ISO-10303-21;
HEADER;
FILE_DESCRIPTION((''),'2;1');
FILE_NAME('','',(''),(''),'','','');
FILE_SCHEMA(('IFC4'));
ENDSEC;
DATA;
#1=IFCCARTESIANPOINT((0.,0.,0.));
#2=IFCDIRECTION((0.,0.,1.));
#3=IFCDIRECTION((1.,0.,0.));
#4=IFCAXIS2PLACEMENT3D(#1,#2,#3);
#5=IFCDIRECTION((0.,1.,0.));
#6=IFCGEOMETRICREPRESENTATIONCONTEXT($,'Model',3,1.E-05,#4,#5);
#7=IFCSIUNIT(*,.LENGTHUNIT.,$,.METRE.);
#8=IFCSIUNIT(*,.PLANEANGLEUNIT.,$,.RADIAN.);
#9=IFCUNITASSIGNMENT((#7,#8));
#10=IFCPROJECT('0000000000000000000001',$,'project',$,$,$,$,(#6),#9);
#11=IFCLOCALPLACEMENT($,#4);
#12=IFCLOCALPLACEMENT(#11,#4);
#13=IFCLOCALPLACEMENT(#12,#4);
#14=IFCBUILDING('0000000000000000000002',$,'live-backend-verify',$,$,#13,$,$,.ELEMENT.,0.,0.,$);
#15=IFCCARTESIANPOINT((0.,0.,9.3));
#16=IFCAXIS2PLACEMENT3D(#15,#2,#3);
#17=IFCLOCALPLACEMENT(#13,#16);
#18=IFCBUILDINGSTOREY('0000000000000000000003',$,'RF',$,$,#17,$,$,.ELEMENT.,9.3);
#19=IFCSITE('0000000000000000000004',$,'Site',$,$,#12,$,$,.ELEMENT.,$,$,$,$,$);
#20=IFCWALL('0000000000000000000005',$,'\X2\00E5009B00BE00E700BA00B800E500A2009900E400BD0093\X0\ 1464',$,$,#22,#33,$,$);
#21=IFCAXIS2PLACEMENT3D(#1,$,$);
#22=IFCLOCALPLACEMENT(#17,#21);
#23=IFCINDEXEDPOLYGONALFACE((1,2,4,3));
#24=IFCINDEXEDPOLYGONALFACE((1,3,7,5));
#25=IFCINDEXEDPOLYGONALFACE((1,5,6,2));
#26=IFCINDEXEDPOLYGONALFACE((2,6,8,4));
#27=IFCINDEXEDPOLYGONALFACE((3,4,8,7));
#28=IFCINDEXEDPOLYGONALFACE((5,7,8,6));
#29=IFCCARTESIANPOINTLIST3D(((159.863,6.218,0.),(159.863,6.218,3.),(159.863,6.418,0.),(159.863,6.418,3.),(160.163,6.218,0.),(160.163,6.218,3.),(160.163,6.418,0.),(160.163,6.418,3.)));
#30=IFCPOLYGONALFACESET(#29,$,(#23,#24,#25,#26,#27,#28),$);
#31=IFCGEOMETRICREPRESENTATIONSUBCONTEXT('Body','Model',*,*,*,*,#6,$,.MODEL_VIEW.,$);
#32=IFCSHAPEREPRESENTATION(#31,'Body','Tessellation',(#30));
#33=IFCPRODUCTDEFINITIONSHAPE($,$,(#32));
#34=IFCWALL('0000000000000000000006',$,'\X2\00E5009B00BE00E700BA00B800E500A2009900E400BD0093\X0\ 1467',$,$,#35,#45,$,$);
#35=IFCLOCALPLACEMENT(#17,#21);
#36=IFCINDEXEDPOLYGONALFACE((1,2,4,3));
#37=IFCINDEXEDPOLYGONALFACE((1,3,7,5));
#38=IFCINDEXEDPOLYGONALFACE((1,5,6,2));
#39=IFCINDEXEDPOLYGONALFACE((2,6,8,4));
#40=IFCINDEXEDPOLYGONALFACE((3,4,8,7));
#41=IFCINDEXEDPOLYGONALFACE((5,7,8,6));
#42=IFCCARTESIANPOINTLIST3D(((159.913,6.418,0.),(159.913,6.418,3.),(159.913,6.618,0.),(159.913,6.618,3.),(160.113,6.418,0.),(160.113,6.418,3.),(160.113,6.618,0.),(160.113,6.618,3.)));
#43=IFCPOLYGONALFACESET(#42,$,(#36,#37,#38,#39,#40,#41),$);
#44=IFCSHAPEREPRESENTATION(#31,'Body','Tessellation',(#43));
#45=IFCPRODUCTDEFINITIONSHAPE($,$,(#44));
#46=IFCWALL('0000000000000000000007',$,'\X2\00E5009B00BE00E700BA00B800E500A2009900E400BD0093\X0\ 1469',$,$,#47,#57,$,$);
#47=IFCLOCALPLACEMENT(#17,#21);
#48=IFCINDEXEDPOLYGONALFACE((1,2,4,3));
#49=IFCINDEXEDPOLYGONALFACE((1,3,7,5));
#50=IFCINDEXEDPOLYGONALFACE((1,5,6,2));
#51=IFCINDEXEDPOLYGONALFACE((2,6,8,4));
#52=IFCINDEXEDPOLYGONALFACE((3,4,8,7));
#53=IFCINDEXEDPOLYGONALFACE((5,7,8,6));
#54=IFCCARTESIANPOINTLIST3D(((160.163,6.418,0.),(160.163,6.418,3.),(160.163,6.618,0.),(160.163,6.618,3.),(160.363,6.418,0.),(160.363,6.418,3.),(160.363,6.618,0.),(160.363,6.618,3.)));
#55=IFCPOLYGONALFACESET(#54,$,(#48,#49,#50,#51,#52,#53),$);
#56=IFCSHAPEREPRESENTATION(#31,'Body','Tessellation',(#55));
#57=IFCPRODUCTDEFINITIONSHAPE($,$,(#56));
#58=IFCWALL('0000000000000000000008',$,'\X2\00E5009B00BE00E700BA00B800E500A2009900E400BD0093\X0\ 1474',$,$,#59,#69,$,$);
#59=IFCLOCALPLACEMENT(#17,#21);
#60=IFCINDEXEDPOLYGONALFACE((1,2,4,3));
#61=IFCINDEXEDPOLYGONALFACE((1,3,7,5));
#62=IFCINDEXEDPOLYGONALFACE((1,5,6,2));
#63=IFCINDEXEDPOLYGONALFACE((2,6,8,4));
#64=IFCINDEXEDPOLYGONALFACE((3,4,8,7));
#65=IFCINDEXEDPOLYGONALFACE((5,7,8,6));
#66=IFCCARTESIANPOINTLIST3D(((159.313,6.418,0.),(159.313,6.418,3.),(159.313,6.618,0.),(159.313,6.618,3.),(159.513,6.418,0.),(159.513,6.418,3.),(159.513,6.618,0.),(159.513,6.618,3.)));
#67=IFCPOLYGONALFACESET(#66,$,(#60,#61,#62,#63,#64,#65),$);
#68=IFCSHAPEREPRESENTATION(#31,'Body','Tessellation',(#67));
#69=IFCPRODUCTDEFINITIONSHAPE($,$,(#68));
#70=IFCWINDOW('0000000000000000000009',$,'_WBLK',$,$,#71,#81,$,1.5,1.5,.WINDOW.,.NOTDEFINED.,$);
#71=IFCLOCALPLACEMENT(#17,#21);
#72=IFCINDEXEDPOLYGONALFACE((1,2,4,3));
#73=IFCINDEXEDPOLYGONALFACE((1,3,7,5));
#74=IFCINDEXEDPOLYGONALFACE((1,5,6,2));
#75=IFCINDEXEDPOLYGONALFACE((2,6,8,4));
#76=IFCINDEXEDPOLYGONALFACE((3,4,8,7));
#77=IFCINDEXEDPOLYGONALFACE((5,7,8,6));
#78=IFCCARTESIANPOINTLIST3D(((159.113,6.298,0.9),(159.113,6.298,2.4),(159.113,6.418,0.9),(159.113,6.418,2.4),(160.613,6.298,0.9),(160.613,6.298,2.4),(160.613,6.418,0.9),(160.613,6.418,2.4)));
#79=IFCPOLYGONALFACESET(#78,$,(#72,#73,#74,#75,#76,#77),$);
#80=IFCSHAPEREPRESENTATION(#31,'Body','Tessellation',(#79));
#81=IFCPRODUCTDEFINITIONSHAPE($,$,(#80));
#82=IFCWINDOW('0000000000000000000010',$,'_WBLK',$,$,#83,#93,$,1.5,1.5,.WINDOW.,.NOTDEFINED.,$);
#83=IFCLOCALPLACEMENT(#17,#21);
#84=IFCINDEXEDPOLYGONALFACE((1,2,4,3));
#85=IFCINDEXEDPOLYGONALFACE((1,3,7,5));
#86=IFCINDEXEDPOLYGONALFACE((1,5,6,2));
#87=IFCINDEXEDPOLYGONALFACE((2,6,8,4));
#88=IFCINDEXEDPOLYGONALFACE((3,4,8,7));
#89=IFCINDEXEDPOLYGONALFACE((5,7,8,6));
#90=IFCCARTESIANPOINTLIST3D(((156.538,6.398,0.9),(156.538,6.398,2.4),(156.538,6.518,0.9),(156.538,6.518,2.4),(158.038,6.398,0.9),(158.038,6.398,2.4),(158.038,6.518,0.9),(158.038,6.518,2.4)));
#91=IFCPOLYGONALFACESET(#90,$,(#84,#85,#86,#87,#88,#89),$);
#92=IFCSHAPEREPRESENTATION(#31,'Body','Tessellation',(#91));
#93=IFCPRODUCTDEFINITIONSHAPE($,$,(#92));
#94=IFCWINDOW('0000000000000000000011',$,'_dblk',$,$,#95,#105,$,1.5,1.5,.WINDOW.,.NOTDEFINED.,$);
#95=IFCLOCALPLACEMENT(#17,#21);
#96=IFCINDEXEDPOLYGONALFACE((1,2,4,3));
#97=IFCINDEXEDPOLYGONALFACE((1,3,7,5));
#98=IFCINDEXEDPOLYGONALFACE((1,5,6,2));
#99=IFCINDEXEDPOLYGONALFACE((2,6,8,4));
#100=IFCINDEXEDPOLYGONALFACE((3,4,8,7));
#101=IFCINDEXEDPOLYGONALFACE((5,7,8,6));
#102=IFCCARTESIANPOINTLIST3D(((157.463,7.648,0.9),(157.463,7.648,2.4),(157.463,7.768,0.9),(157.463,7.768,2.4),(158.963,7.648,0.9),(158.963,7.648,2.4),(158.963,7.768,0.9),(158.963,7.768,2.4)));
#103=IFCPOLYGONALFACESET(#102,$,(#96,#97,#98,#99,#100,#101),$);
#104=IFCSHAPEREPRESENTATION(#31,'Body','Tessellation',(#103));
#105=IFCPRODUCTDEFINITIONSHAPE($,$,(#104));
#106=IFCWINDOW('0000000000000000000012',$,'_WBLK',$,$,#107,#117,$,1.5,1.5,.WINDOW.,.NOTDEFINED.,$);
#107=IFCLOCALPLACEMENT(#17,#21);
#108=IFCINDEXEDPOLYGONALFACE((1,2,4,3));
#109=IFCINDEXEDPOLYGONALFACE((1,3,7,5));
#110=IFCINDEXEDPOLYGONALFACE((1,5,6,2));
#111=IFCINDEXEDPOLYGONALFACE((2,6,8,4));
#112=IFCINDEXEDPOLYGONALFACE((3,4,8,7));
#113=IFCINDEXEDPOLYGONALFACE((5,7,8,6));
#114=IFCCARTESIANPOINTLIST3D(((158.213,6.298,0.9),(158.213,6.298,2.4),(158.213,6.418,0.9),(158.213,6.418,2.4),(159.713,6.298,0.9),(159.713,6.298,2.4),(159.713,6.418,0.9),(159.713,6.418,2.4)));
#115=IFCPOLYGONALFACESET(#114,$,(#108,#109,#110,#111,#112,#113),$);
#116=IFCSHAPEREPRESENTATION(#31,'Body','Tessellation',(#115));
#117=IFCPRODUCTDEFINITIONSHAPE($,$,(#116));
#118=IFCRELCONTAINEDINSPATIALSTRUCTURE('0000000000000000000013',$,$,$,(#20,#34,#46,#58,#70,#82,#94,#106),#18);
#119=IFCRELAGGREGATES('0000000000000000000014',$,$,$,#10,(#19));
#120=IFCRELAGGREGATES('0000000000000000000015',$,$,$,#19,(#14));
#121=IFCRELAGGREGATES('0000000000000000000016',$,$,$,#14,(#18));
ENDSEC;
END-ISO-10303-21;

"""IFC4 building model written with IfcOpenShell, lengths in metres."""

from ifc_helpers import new_model, si_unit, direction, frame, frame_2d, origin_with_axes, place, context, subcontext, project, spatial, rectangle, extrude, element, save


model = new_model("IFC4")

# Units and contexts
model_context = context("Model", 3, precision=1e-05, world=origin_with_axes(), true_north=direction((0.0, 1.0, 0.0)))
body_context = subcontext(model_context, "Body", "Model", "MODEL_VIEW")
ifc_project = project(units=[si_unit("LENGTHUNIT", "METRE"), si_unit("PLANEANGLEUNIT", "RADIAN")], contexts=[model_context])

# Site, building, storey
placement = place(None, origin_with_axes())
site_placement = place(placement, origin_with_axes())
site = spatial("IfcSite", under=ifc_project, at=site_placement, Name="Site", CompositionType="ELEMENT")
building_placement = place(site_placement, origin_with_axes())
building = spatial("IfcBuilding", under=site, at=building_placement, Name="live-backend-verify", CompositionType="ELEMENT", ElevationOfRefHeight=0.0, ElevationOfTerrain=0.0)
storey_placement = place(building_placement, frame((0.0, 0.0, 9.3), z_axis=(0.0, 0.0, 1.0), x_axis=(1.0, 0.0, 0.0)))
storey = spatial("IfcBuildingStorey", under=building, at=storey_placement, Name="RF", CompositionType="ELEMENT", Elevation=9.3)

# Walls
wall_1_placement = place(storey_placement, frame((160.013, 6.318, 0.0), z_axis=(0.0, 0.0, 1.0), x_axis=(1.0, 0.0, 0.0)))
element("IfcWall", 1, at=wall_1_placement, inside=storey, Name="å\u009b¾çº¸å¢\u0099ä½\u0093 1464", context=body_context, shape_type="SweptSolid", body=[
    extrude(rectangle(XDim=0.3, YDim=0.2, at=frame_2d((0.0, 0.0), x_axis=(1.0, 0.0, 0.0))), frame((0.0, 0.0, 0.0), z_axis=(0.0, 0.0, 1.0)), (0.0, 0.0, 1.0), 3.0),
])
for number, where, z_axis, x_axis, name in (
    (2, (160.013, 6.518, 0.0), (0.0, 0.0, 1.0), (1.0, 0.0, 0.0), "å\u009b¾çº¸å¢\u0099ä½\u0093 1467"),
    (3, (160.263, 6.518, 0.0), (0.0, 0.0, 1.0), (1.0, 0.0, 0.0), "å\u009b¾çº¸å¢\u0099ä½\u0093 1469"),
    (4, (159.413, 6.518, 0.0), (0.0, 0.0, 1.0), (0.0, -1.0, 0.0), "å\u009b¾çº¸å¢\u0099ä½\u0093 1474"),
):
    element("IfcWall", number, at=place(storey_placement, frame(where, z_axis=z_axis, x_axis=x_axis)), inside=storey, Name=name, context=body_context, shape_type="SweptSolid", body=[
        extrude(rectangle(XDim=0.2, YDim=0.2, at=frame_2d((0.0, 0.0), x_axis=(1.0, 0.0, 0.0))), frame((0.0, 0.0, 0.0), z_axis=(0.0, 0.0, 1.0)), (0.0, 0.0, 1.0), 3.0),
    ])

# Windows
for number, where, z_axis, x_axis, name in (
    (5, (159.863, 6.358, 0.9), (0.0, 0.0, 1.0), (1.0, 0.0, 0.0), "_WBLK"),
    (6, (157.288, 6.458, 0.9), (0.0, 0.0, 1.0), (1.0, 0.0, 0.0), "_WBLK"),
    (7, (158.213, 7.708, 0.9), (0.0, 0.0, 1.0), (1.0, 0.0, 0.0), "_dblk"),
    (8, (158.963, 6.358, 0.9), (0.0, 0.0, 1.0), (1.0, 0.0, 0.0), "_WBLK"),
):
    element("IfcWindow", number, at=place(storey_placement, frame(where, z_axis=z_axis, x_axis=x_axis)), inside=storey, Name=name, OverallHeight=1.5, OverallWidth=1.5, PartitioningType="NOTDEFINED", PredefinedType="WINDOW", context=body_context, shape_type="SweptSolid", body=[
        extrude(rectangle(XDim=1.5, YDim=0.12, at=frame_2d((0.0, 0.0), x_axis=(1.0, 0.0, 0.0))), frame((0.0, 0.0, 0.0), z_axis=(0.0, 0.0, 1.0)), (0.0, 0.0, 1.0), 1.5),
    ])

save(model, "model.ifc")
